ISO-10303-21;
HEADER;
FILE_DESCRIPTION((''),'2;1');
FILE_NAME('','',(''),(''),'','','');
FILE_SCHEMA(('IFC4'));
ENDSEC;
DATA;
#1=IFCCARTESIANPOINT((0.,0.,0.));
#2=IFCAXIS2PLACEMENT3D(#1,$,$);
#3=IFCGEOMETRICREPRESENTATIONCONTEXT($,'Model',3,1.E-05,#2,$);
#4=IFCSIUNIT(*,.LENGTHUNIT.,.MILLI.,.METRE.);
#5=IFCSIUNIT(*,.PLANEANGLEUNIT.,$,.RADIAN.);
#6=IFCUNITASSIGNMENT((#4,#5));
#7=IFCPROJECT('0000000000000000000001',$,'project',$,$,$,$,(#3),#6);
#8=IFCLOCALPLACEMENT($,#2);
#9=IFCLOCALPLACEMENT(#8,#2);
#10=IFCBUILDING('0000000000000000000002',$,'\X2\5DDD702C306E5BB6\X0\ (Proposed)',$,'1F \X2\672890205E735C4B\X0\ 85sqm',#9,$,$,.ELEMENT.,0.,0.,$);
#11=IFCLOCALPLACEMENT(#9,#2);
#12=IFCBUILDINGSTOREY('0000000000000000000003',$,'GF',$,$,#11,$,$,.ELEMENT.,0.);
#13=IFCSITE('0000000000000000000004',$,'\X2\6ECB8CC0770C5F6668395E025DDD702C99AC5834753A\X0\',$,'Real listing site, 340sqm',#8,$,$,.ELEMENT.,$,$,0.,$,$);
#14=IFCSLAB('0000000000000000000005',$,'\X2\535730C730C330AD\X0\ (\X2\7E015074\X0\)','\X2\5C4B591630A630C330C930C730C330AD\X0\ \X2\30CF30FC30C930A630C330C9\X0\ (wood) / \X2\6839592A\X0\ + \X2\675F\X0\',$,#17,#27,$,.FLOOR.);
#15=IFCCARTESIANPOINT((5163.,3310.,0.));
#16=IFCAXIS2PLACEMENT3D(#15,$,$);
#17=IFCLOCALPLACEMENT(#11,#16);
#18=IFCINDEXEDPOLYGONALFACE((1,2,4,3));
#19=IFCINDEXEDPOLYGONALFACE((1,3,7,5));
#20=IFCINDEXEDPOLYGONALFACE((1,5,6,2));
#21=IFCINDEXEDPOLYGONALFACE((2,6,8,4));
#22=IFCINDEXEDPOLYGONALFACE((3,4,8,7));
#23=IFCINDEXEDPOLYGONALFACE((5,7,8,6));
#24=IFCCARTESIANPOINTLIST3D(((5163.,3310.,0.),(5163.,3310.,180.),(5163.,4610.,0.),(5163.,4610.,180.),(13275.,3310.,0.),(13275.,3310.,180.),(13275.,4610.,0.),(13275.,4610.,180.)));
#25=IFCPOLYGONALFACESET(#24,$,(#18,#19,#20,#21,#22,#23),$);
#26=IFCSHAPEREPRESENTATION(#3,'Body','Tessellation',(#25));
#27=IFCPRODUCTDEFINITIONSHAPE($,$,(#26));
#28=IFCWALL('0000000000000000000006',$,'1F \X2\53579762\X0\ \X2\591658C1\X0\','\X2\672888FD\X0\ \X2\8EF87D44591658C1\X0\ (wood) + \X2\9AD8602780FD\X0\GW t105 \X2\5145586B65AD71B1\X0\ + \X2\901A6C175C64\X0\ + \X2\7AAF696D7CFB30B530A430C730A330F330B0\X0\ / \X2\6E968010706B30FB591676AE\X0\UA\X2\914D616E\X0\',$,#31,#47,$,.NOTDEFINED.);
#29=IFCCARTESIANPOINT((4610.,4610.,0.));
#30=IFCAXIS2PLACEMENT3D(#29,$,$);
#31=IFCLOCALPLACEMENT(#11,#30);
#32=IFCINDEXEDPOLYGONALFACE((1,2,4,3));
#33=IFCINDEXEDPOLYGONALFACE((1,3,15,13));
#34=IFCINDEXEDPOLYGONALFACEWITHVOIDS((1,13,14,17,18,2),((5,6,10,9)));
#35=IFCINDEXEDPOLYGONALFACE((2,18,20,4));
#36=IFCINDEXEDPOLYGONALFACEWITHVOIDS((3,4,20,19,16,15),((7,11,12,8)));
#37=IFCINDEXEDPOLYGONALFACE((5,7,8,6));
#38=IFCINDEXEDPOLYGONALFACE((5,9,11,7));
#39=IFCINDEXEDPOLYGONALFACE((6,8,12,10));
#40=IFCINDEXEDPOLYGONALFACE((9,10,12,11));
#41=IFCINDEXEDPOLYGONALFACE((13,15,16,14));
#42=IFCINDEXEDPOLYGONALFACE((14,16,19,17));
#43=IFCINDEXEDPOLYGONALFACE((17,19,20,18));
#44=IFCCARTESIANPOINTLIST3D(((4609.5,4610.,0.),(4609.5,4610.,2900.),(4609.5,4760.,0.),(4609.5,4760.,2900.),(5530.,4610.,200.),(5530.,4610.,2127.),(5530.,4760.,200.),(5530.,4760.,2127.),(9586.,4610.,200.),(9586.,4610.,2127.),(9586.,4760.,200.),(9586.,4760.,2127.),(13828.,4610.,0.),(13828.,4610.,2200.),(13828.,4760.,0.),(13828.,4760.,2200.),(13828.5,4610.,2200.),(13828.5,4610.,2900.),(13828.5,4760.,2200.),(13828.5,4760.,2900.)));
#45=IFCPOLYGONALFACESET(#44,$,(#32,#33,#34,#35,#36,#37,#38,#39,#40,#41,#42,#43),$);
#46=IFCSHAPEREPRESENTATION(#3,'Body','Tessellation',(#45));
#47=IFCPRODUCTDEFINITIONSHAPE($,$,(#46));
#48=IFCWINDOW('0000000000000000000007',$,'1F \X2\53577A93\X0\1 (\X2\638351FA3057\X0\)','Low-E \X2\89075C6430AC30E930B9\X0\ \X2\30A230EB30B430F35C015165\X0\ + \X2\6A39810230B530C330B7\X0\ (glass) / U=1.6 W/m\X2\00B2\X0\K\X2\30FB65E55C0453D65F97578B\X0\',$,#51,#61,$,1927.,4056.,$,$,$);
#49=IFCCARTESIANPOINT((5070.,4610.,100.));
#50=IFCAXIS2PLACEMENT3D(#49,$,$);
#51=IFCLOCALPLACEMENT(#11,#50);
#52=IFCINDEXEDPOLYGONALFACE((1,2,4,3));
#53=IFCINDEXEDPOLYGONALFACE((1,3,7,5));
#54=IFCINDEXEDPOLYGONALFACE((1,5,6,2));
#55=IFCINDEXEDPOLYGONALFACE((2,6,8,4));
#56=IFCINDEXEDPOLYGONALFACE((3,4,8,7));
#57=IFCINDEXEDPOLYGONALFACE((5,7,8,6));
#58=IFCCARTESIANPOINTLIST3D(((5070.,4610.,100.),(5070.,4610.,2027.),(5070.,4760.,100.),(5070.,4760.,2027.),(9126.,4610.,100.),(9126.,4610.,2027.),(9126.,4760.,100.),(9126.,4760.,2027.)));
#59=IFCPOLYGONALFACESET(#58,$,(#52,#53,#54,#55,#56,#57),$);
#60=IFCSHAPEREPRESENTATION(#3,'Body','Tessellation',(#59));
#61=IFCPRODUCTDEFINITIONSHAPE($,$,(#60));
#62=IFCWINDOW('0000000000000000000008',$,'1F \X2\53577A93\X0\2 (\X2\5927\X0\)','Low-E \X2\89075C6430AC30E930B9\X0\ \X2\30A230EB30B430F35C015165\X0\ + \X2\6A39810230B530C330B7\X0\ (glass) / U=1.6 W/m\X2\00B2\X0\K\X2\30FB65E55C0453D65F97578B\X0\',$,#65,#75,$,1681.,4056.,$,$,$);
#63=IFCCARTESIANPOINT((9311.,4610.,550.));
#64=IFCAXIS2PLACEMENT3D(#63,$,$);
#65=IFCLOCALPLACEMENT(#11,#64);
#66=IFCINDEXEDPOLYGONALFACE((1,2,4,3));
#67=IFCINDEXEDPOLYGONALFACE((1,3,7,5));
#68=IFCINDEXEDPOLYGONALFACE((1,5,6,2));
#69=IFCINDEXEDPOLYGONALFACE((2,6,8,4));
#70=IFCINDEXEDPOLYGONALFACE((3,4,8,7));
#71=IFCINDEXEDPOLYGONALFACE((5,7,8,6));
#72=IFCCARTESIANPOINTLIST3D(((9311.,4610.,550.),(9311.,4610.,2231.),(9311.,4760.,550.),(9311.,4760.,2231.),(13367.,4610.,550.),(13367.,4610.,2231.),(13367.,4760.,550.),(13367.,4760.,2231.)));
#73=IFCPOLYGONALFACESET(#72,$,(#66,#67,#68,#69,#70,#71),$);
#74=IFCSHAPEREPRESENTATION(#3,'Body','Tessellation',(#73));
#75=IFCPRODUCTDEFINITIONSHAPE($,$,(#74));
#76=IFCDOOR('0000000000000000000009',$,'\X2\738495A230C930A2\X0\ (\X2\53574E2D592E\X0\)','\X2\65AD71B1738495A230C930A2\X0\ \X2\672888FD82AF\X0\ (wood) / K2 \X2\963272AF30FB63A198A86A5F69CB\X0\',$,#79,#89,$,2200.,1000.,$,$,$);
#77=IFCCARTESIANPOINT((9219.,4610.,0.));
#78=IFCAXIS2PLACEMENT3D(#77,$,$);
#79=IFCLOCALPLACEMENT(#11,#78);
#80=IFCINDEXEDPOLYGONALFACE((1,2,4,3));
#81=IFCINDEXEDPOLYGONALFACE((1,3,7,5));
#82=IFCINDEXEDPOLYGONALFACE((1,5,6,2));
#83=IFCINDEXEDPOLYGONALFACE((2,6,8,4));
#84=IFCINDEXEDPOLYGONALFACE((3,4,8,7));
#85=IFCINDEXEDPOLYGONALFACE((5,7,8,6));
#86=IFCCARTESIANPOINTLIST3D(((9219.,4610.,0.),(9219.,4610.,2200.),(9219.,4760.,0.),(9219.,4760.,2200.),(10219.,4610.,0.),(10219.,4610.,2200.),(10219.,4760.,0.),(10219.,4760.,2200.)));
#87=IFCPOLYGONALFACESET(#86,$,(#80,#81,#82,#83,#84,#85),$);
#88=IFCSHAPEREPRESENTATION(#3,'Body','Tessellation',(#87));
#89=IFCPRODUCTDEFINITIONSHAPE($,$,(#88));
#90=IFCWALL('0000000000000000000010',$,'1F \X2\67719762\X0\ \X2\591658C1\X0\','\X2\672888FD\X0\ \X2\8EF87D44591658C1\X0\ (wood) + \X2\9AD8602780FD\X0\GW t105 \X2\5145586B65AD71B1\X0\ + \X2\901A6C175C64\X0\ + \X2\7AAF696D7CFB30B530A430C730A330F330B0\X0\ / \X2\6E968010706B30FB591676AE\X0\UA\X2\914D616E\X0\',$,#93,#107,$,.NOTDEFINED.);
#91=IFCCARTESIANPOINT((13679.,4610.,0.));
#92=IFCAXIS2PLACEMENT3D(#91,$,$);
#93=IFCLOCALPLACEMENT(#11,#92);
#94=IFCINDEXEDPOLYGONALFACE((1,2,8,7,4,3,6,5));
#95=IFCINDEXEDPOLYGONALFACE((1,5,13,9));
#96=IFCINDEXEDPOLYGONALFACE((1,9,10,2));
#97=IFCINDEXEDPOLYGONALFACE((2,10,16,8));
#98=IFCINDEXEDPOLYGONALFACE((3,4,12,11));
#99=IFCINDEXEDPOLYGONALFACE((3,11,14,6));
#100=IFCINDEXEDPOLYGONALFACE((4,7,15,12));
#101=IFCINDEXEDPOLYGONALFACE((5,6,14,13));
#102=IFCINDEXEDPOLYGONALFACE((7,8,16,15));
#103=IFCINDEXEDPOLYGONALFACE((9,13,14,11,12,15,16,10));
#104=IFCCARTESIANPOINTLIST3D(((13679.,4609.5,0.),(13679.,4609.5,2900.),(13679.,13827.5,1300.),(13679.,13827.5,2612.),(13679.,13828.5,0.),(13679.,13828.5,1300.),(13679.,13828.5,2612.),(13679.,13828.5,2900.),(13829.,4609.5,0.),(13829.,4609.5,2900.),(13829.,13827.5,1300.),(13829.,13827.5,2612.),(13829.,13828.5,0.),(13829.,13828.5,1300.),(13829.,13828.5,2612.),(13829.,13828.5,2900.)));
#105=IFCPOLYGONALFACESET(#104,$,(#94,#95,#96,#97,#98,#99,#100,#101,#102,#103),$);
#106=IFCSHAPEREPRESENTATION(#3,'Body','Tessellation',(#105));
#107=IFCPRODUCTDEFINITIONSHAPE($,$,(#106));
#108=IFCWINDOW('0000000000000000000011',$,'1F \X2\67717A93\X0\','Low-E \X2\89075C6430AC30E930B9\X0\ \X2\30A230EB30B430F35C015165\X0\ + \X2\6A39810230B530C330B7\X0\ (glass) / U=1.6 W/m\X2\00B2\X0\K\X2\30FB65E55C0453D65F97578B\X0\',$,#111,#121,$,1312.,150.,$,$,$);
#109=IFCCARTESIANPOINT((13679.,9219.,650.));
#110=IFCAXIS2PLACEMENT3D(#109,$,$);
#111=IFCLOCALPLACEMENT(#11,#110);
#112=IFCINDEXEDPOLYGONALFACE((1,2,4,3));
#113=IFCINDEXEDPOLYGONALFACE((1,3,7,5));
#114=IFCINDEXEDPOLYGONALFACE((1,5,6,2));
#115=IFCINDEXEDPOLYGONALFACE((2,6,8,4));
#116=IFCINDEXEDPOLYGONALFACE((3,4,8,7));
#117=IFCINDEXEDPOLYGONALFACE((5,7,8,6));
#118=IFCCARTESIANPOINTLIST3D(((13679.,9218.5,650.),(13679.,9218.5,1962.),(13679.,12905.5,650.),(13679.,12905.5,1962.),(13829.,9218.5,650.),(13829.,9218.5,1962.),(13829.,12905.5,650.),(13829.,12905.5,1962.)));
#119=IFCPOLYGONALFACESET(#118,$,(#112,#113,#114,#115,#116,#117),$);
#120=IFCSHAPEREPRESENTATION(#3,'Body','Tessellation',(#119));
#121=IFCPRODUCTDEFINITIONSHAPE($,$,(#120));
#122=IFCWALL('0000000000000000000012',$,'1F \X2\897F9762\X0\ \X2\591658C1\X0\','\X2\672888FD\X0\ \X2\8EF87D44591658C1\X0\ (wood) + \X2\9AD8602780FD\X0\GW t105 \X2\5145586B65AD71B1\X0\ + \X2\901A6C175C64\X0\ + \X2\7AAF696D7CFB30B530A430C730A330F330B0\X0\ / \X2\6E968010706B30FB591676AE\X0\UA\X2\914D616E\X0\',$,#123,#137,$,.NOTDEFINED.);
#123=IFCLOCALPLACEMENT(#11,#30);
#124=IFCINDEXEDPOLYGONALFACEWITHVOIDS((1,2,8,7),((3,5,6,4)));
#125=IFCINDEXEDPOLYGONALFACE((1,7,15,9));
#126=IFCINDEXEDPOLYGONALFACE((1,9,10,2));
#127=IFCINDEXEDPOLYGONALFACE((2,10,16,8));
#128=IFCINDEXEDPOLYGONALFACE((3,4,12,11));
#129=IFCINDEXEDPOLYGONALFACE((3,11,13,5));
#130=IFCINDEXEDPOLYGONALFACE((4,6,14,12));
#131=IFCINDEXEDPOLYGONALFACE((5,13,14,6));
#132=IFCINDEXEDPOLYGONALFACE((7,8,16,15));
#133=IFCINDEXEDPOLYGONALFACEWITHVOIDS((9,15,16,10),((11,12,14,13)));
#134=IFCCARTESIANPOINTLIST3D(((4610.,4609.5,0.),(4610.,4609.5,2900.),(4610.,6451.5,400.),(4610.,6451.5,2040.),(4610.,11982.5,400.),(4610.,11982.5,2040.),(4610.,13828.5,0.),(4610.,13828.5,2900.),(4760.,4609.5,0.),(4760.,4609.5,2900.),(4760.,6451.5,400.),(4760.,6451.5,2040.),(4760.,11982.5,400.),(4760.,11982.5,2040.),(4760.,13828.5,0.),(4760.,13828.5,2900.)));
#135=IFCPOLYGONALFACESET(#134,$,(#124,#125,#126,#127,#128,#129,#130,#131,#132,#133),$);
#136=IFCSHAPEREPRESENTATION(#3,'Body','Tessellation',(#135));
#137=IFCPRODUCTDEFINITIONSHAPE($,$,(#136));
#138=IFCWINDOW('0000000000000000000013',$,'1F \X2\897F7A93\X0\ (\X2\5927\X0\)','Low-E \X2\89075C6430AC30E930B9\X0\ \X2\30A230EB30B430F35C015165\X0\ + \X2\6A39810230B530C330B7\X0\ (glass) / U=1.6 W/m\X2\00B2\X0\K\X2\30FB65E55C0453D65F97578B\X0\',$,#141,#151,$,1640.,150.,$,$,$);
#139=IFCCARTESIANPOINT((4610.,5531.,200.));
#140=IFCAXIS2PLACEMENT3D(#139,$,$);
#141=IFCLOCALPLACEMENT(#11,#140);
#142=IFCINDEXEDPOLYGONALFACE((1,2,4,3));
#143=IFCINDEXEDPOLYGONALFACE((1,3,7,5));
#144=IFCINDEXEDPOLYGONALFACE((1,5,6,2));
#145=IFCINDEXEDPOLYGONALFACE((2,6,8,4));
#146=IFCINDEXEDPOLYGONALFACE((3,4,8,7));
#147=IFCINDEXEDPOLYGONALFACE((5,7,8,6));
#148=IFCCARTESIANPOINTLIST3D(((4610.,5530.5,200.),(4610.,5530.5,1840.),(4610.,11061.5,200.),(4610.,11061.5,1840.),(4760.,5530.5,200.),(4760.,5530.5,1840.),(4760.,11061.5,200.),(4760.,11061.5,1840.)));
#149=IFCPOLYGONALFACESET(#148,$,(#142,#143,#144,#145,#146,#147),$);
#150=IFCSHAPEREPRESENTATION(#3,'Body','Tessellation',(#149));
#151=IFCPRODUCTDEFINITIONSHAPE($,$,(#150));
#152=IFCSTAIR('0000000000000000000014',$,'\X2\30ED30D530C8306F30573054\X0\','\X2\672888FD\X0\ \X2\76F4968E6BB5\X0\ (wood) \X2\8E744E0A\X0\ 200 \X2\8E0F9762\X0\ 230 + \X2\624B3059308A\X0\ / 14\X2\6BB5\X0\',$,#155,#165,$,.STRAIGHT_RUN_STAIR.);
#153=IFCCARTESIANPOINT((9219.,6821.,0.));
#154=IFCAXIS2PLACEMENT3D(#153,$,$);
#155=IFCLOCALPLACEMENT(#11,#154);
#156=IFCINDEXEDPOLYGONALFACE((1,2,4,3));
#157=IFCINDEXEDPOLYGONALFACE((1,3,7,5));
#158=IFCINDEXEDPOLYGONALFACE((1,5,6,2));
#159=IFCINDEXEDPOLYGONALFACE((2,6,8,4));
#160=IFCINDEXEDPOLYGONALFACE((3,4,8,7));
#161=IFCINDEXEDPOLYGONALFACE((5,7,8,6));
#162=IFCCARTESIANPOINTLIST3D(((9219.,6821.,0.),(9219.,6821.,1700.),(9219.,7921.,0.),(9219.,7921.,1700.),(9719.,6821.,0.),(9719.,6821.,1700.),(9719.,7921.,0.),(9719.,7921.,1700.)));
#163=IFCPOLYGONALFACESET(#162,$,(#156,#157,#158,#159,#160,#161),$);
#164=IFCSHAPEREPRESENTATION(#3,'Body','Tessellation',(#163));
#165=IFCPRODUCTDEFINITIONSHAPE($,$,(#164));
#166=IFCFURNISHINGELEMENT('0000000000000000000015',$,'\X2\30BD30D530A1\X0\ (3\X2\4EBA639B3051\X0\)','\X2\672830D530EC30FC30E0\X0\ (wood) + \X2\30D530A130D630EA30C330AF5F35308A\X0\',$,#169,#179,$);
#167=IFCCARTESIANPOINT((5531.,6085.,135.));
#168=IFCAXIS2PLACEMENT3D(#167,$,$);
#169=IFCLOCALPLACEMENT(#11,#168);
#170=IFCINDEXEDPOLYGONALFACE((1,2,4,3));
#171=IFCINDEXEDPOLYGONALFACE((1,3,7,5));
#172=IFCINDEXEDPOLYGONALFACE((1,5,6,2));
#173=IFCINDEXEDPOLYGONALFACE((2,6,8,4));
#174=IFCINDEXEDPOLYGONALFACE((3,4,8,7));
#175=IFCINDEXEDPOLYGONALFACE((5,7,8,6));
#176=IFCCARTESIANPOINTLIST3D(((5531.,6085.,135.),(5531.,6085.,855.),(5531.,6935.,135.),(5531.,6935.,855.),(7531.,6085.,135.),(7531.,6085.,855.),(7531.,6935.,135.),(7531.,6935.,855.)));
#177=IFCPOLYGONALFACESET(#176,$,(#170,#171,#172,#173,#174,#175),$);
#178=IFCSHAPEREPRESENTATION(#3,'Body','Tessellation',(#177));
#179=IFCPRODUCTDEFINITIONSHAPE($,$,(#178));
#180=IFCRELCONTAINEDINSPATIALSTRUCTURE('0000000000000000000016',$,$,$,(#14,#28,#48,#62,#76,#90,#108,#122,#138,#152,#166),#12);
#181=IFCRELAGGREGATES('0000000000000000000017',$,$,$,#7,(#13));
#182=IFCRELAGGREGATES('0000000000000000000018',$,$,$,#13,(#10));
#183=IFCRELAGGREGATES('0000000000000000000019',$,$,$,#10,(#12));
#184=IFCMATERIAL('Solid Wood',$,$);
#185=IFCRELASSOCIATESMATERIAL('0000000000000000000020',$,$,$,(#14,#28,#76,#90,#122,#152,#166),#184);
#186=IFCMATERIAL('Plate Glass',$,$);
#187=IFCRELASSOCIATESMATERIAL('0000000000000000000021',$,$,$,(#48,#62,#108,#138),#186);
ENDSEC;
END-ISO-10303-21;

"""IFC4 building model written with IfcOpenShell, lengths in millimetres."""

from ifc_helpers import new_model, si_unit, frame, frame_2d, origin, place, context, project, spatial, rectangle, extrude, material, element, fill, save


model = new_model("IFC4")

# Units and contexts
model_context = context("Model", 3, precision=1e-05, world=origin())
ifc_project = project(units=[si_unit("LENGTHUNIT", "METRE", prefix="MILLI"), si_unit("PLANEANGLEUNIT", "RADIAN")], contexts=[model_context])

# Site, building, storey
site_placement = place(None, origin())
site = spatial("IfcSite", under=ifc_project, at=site_placement, Name="滋賀県彦根市川瀬馬場町", ObjectType="Real listing site, 340sqm", CompositionType="ELEMENT", RefElevation=0.0)
building_placement = place(site_placement, origin())
building = spatial("IfcBuilding", under=site, at=building_placement, Name="川瀬の家 (Proposed)", ObjectType="1F 木造平屋 85sqm", CompositionType="ELEMENT", ElevationOfRefHeight=0.0, ElevationOfTerrain=0.0)
storey_placement = place(building_placement, origin())
storey = spatial("IfcBuildingStorey", under=building, at=storey_placement, Name="GF", CompositionType="ELEMENT", Elevation=0.0)

# Slab
ifc_material_1 = material(Name="Solid Wood")
slab_1_placement = place(storey_placement, frame((5163.0, 3310.0, 0.0)))
element("IfcSlab", 1, at=slab_1_placement, inside=storey, material=ifc_material_1, Name="南デッキ (縁側)", Description="屋外ウッドデッキ ハードウッド (wood) / 根太 + 束", PredefinedType="FLOOR", context=model_context, shape_type="SweptSolid", body=[
    extrude(rectangle(XDim=8112.0, YDim=1300.0, at=frame_2d((4056.0, 650.0))), frame((5163.0, 3310.0, 0.0)), (0.0, 0.0, 1.0), 180.0),
])

# Wall, openings, windows, door
wall_1_placement = place(storey_placement, frame((4610.0, 4610.0, 0.0)))
wall_1 = element("IfcWall", 2, at=wall_1_placement, inside=storey, material=ifc_material_1, Name="1F 南面 外壁", Description="木製 軸組外壁 (wood) + 高性能GW t105 充填断熱 + 通気層 + 窯業系サイディング / 準耐火・外皮UA配慮", PredefinedType="NOTDEFINED", context=model_context, shape_type="SweptSolid", body=[
    extrude(rectangle(XDim=9219.0, YDim=150.0, at=frame_2d((4609.0, 75.0))), frame((4610.0, 4610.0, 0.0)), (0.0, 0.0, 1.0), 2900.0),
])
opening_1_placement = place(storey_placement, frame((5070.0, 4610.0, 100.0)))
opening_1 = element("IfcOpeningElement", 3, at=opening_1_placement, cuts=wall_1, PredefinedType="NOTDEFINED", context=model_context, shape_type="SweptSolid", body=[
    extrude(rectangle(XDim=4056.0, YDim=150.0, at=frame_2d((2028.0, 75.0))), frame((5070.0, 4610.0, 100.0)), (0.0, 0.0, 1.0), 1927.0),
])
opening_2_placement = place(storey_placement, frame((9311.0, 4610.0, 550.0)))
opening_2 = element("IfcOpeningElement", 4, at=opening_2_placement, cuts=wall_1, PredefinedType="NOTDEFINED", context=model_context, shape_type="SweptSolid", body=[
    extrude(rectangle(XDim=4056.0, YDim=150.0, at=frame_2d((2028.0, 75.0))), frame((9311.0, 4610.0, 550.0)), (0.0, 0.0, 1.0), 1681.0),
])
opening_3_placement = place(storey_placement, frame((9219.0, 4610.0, 0.0)))
opening_3 = element("IfcOpeningElement", 5, at=opening_3_placement, cuts=wall_1, PredefinedType="NOTDEFINED", context=model_context, shape_type="SweptSolid", body=[
    extrude(rectangle(XDim=1000.0, YDim=150.0, at=frame_2d((500.0, 75.0))), frame((9219.0, 4610.0, 0.0)), (0.0, 0.0, 1.0), 2200.0),
])
ifc_material_2 = material(Name="Plate Glass")
window_1_placement = place(storey_placement, frame((5070.0, 4610.0, 100.0)))
window_1 = element("IfcWindow", 6, at=window_1_placement, inside=storey, material=ifc_material_2, Name="1F 南窓1 (掃出し)", Description="Low-E 複層ガラス アルゴン封入 + 樹脂サッシ (glass) / U=1.6 W/m²K・日射取得型", OverallHeight=1927.0, OverallWidth=4056.0, context=model_context, shape_type="SweptSolid", body=[
    extrude(rectangle(XDim=4056.0, YDim=150.0, at=frame_2d((2028.0, 75.0))), frame((5070.0, 4610.0, 100.0)), (0.0, 0.0, 1.0), 1927.0),
])
fill(opening_1, window_1)
window_2_placement = place(storey_placement, frame((9311.0, 4610.0, 550.0)))
window_2 = element("IfcWindow", 7, at=window_2_placement, inside=storey, material=ifc_material_2, Name="1F 南窓2 (大)", Description="Low-E 複層ガラス アルゴン封入 + 樹脂サッシ (glass) / U=1.6 W/m²K・日射取得型", OverallHeight=1681.0, OverallWidth=4056.0, context=model_context, shape_type="SweptSolid", body=[
    extrude(rectangle(XDim=4056.0, YDim=150.0, at=frame_2d((2028.0, 75.0))), frame((9311.0, 4610.0, 550.0)), (0.0, 0.0, 1.0), 1681.0),
])
fill(opening_2, window_2)
door_placement = place(storey_placement, frame((9219.0, 4610.0, 0.0)))
door = element("IfcDoor", 8, at=door_placement, inside=storey, material=ifc_material_1, Name="玄関ドア (南中央)", Description="断熱玄関ドア 木製芯 (wood) / K2 防犯・採風機構", OverallHeight=2200.0, OverallWidth=1000.0, context=model_context, shape_type="SweptSolid", body=[
    extrude(rectangle(XDim=1000.0, YDim=150.0, at=frame_2d((500.0, 75.0))), frame((9219.0, 4610.0, 0.0)), (0.0, 0.0, 1.0), 2200.0),
])
fill(opening_3, door)

# Walls, openings, windows
wall_2_placement = place(storey_placement, frame((13679.0, 4610.0, 0.0)))
wall_2 = element("IfcWall", 9, at=wall_2_placement, inside=storey, material=ifc_material_1, Name="1F 東面 外壁", Description="木製 軸組外壁 (wood) + 高性能GW t105 充填断熱 + 通気層 + 窯業系サイディング / 準耐火・外皮UA配慮", PredefinedType="NOTDEFINED", context=model_context, shape_type="SweptSolid", body=[
    extrude(rectangle(XDim=150.0, YDim=9219.0, at=frame_2d((75.0, 4609.0))), frame((13679.0, 4610.0, 0.0)), (0.0, 0.0, 1.0), 2900.0),
])
opening_4_placement = place(storey_placement, frame((13679.0, 9219.0, 650.0)))
opening_4 = element("IfcOpeningElement", 10, at=opening_4_placement, cuts=wall_2, PredefinedType="NOTDEFINED", context=model_context, shape_type="SweptSolid", body=[
    extrude(rectangle(XDim=150.0, YDim=3687.0, at=frame_2d((75.0, 1843.0))), frame((13679.0, 9219.0, 650.0)), (0.0, 0.0, 1.0), 1312.0),
])
window_3_placement = place(storey_placement, frame((13679.0, 9219.0, 650.0)))
window_3 = element("IfcWindow", 11, at=window_3_placement, inside=storey, material=ifc_material_2, Name="1F 東窓", Description="Low-E 複層ガラス アルゴン封入 + 樹脂サッシ (glass) / U=1.6 W/m²K・日射取得型", OverallHeight=1312.0, OverallWidth=150.0, context=model_context, shape_type="SweptSolid", body=[
    extrude(rectangle(XDim=150.0, YDim=3687.0, at=frame_2d((75.0, 1843.0))), frame((13679.0, 9219.0, 650.0)), (0.0, 0.0, 1.0), 1312.0),
])
fill(opening_4, window_3)
wall_3_placement = place(storey_placement, frame((4610.0, 4610.0, 0.0)))
wall_3 = element("IfcWall", 12, at=wall_3_placement, inside=storey, material=ifc_material_1, Name="1F 西面 外壁", Description="木製 軸組外壁 (wood) + 高性能GW t105 充填断熱 + 通気層 + 窯業系サイディング / 準耐火・外皮UA配慮", PredefinedType="NOTDEFINED", context=model_context, shape_type="SweptSolid", body=[
    extrude(rectangle(XDim=150.0, YDim=9219.0, at=frame_2d((75.0, 4609.0))), frame((4610.0, 4610.0, 0.0)), (0.0, 0.0, 1.0), 2900.0),
])
opening_5_placement = place(storey_placement, frame((4610.0, 5531.0, 200.0)))
opening_5 = element("IfcOpeningElement", 13, at=opening_5_placement, cuts=wall_3, PredefinedType="NOTDEFINED", context=model_context, shape_type="SweptSolid", body=[
    extrude(rectangle(XDim=150.0, YDim=5531.0, at=frame_2d((75.0, 2765.0))), frame((4610.0, 5531.0, 200.0)), (0.0, 0.0, 1.0), 1640.0),
])
window_4_placement = place(storey_placement, frame((4610.0, 5531.0, 200.0)))
window_4 = element("IfcWindow", 14, at=window_4_placement, inside=storey, material=ifc_material_2, Name="1F 西窓 (大)", Description="Low-E 複層ガラス アルゴン封入 + 樹脂サッシ (glass) / U=1.6 W/m²K・日射取得型", OverallHeight=1640.0, OverallWidth=150.0, context=model_context, shape_type="SweptSolid", body=[
    extrude(rectangle(XDim=150.0, YDim=5531.0, at=frame_2d((75.0, 2765.0))), frame((4610.0, 5531.0, 200.0)), (0.0, 0.0, 1.0), 1640.0),
])
fill(opening_5, window_4)

# Stair
stair_placement = place(storey_placement, frame((9219.0, 6821.0, 0.0)))
element("IfcStair", 15, at=stair_placement, inside=storey, material=ifc_material_1, Name="ロフトはしご", Description="木製 直階段 (wood) 蹴上 200 踏面 230 + 手すり / 14段", PredefinedType="STRAIGHT_RUN_STAIR", context=model_context, shape_type="SweptSolid", body=[
    extrude(rectangle(XDim=500.0, YDim=1100.0, at=frame_2d((250.0, 550.0))), frame((9219.0, 6821.0, 0.0)), (0.0, 0.0, 1.0), 1700.0),
])

# Furnishing element
furnishing_1_placement = place(storey_placement, frame((5531.0, 6085.0, 135.0)))
element("IfcFurnishingElement", 16, at=furnishing_1_placement, inside=storey, material=ifc_material_1, Name="ソファ (3人掛け)", Description="木フレーム (wood) + ファブリック張り", context=model_context, shape_type="SweptSolid", body=[
    extrude(rectangle(XDim=2000.0, YDim=850.0, at=frame_2d((1000.0, 425.0))), frame((5531.0, 6085.0, 135.0)), (0.0, 0.0, 1.0), 720.0),
])

save(model, "model.ifc")
